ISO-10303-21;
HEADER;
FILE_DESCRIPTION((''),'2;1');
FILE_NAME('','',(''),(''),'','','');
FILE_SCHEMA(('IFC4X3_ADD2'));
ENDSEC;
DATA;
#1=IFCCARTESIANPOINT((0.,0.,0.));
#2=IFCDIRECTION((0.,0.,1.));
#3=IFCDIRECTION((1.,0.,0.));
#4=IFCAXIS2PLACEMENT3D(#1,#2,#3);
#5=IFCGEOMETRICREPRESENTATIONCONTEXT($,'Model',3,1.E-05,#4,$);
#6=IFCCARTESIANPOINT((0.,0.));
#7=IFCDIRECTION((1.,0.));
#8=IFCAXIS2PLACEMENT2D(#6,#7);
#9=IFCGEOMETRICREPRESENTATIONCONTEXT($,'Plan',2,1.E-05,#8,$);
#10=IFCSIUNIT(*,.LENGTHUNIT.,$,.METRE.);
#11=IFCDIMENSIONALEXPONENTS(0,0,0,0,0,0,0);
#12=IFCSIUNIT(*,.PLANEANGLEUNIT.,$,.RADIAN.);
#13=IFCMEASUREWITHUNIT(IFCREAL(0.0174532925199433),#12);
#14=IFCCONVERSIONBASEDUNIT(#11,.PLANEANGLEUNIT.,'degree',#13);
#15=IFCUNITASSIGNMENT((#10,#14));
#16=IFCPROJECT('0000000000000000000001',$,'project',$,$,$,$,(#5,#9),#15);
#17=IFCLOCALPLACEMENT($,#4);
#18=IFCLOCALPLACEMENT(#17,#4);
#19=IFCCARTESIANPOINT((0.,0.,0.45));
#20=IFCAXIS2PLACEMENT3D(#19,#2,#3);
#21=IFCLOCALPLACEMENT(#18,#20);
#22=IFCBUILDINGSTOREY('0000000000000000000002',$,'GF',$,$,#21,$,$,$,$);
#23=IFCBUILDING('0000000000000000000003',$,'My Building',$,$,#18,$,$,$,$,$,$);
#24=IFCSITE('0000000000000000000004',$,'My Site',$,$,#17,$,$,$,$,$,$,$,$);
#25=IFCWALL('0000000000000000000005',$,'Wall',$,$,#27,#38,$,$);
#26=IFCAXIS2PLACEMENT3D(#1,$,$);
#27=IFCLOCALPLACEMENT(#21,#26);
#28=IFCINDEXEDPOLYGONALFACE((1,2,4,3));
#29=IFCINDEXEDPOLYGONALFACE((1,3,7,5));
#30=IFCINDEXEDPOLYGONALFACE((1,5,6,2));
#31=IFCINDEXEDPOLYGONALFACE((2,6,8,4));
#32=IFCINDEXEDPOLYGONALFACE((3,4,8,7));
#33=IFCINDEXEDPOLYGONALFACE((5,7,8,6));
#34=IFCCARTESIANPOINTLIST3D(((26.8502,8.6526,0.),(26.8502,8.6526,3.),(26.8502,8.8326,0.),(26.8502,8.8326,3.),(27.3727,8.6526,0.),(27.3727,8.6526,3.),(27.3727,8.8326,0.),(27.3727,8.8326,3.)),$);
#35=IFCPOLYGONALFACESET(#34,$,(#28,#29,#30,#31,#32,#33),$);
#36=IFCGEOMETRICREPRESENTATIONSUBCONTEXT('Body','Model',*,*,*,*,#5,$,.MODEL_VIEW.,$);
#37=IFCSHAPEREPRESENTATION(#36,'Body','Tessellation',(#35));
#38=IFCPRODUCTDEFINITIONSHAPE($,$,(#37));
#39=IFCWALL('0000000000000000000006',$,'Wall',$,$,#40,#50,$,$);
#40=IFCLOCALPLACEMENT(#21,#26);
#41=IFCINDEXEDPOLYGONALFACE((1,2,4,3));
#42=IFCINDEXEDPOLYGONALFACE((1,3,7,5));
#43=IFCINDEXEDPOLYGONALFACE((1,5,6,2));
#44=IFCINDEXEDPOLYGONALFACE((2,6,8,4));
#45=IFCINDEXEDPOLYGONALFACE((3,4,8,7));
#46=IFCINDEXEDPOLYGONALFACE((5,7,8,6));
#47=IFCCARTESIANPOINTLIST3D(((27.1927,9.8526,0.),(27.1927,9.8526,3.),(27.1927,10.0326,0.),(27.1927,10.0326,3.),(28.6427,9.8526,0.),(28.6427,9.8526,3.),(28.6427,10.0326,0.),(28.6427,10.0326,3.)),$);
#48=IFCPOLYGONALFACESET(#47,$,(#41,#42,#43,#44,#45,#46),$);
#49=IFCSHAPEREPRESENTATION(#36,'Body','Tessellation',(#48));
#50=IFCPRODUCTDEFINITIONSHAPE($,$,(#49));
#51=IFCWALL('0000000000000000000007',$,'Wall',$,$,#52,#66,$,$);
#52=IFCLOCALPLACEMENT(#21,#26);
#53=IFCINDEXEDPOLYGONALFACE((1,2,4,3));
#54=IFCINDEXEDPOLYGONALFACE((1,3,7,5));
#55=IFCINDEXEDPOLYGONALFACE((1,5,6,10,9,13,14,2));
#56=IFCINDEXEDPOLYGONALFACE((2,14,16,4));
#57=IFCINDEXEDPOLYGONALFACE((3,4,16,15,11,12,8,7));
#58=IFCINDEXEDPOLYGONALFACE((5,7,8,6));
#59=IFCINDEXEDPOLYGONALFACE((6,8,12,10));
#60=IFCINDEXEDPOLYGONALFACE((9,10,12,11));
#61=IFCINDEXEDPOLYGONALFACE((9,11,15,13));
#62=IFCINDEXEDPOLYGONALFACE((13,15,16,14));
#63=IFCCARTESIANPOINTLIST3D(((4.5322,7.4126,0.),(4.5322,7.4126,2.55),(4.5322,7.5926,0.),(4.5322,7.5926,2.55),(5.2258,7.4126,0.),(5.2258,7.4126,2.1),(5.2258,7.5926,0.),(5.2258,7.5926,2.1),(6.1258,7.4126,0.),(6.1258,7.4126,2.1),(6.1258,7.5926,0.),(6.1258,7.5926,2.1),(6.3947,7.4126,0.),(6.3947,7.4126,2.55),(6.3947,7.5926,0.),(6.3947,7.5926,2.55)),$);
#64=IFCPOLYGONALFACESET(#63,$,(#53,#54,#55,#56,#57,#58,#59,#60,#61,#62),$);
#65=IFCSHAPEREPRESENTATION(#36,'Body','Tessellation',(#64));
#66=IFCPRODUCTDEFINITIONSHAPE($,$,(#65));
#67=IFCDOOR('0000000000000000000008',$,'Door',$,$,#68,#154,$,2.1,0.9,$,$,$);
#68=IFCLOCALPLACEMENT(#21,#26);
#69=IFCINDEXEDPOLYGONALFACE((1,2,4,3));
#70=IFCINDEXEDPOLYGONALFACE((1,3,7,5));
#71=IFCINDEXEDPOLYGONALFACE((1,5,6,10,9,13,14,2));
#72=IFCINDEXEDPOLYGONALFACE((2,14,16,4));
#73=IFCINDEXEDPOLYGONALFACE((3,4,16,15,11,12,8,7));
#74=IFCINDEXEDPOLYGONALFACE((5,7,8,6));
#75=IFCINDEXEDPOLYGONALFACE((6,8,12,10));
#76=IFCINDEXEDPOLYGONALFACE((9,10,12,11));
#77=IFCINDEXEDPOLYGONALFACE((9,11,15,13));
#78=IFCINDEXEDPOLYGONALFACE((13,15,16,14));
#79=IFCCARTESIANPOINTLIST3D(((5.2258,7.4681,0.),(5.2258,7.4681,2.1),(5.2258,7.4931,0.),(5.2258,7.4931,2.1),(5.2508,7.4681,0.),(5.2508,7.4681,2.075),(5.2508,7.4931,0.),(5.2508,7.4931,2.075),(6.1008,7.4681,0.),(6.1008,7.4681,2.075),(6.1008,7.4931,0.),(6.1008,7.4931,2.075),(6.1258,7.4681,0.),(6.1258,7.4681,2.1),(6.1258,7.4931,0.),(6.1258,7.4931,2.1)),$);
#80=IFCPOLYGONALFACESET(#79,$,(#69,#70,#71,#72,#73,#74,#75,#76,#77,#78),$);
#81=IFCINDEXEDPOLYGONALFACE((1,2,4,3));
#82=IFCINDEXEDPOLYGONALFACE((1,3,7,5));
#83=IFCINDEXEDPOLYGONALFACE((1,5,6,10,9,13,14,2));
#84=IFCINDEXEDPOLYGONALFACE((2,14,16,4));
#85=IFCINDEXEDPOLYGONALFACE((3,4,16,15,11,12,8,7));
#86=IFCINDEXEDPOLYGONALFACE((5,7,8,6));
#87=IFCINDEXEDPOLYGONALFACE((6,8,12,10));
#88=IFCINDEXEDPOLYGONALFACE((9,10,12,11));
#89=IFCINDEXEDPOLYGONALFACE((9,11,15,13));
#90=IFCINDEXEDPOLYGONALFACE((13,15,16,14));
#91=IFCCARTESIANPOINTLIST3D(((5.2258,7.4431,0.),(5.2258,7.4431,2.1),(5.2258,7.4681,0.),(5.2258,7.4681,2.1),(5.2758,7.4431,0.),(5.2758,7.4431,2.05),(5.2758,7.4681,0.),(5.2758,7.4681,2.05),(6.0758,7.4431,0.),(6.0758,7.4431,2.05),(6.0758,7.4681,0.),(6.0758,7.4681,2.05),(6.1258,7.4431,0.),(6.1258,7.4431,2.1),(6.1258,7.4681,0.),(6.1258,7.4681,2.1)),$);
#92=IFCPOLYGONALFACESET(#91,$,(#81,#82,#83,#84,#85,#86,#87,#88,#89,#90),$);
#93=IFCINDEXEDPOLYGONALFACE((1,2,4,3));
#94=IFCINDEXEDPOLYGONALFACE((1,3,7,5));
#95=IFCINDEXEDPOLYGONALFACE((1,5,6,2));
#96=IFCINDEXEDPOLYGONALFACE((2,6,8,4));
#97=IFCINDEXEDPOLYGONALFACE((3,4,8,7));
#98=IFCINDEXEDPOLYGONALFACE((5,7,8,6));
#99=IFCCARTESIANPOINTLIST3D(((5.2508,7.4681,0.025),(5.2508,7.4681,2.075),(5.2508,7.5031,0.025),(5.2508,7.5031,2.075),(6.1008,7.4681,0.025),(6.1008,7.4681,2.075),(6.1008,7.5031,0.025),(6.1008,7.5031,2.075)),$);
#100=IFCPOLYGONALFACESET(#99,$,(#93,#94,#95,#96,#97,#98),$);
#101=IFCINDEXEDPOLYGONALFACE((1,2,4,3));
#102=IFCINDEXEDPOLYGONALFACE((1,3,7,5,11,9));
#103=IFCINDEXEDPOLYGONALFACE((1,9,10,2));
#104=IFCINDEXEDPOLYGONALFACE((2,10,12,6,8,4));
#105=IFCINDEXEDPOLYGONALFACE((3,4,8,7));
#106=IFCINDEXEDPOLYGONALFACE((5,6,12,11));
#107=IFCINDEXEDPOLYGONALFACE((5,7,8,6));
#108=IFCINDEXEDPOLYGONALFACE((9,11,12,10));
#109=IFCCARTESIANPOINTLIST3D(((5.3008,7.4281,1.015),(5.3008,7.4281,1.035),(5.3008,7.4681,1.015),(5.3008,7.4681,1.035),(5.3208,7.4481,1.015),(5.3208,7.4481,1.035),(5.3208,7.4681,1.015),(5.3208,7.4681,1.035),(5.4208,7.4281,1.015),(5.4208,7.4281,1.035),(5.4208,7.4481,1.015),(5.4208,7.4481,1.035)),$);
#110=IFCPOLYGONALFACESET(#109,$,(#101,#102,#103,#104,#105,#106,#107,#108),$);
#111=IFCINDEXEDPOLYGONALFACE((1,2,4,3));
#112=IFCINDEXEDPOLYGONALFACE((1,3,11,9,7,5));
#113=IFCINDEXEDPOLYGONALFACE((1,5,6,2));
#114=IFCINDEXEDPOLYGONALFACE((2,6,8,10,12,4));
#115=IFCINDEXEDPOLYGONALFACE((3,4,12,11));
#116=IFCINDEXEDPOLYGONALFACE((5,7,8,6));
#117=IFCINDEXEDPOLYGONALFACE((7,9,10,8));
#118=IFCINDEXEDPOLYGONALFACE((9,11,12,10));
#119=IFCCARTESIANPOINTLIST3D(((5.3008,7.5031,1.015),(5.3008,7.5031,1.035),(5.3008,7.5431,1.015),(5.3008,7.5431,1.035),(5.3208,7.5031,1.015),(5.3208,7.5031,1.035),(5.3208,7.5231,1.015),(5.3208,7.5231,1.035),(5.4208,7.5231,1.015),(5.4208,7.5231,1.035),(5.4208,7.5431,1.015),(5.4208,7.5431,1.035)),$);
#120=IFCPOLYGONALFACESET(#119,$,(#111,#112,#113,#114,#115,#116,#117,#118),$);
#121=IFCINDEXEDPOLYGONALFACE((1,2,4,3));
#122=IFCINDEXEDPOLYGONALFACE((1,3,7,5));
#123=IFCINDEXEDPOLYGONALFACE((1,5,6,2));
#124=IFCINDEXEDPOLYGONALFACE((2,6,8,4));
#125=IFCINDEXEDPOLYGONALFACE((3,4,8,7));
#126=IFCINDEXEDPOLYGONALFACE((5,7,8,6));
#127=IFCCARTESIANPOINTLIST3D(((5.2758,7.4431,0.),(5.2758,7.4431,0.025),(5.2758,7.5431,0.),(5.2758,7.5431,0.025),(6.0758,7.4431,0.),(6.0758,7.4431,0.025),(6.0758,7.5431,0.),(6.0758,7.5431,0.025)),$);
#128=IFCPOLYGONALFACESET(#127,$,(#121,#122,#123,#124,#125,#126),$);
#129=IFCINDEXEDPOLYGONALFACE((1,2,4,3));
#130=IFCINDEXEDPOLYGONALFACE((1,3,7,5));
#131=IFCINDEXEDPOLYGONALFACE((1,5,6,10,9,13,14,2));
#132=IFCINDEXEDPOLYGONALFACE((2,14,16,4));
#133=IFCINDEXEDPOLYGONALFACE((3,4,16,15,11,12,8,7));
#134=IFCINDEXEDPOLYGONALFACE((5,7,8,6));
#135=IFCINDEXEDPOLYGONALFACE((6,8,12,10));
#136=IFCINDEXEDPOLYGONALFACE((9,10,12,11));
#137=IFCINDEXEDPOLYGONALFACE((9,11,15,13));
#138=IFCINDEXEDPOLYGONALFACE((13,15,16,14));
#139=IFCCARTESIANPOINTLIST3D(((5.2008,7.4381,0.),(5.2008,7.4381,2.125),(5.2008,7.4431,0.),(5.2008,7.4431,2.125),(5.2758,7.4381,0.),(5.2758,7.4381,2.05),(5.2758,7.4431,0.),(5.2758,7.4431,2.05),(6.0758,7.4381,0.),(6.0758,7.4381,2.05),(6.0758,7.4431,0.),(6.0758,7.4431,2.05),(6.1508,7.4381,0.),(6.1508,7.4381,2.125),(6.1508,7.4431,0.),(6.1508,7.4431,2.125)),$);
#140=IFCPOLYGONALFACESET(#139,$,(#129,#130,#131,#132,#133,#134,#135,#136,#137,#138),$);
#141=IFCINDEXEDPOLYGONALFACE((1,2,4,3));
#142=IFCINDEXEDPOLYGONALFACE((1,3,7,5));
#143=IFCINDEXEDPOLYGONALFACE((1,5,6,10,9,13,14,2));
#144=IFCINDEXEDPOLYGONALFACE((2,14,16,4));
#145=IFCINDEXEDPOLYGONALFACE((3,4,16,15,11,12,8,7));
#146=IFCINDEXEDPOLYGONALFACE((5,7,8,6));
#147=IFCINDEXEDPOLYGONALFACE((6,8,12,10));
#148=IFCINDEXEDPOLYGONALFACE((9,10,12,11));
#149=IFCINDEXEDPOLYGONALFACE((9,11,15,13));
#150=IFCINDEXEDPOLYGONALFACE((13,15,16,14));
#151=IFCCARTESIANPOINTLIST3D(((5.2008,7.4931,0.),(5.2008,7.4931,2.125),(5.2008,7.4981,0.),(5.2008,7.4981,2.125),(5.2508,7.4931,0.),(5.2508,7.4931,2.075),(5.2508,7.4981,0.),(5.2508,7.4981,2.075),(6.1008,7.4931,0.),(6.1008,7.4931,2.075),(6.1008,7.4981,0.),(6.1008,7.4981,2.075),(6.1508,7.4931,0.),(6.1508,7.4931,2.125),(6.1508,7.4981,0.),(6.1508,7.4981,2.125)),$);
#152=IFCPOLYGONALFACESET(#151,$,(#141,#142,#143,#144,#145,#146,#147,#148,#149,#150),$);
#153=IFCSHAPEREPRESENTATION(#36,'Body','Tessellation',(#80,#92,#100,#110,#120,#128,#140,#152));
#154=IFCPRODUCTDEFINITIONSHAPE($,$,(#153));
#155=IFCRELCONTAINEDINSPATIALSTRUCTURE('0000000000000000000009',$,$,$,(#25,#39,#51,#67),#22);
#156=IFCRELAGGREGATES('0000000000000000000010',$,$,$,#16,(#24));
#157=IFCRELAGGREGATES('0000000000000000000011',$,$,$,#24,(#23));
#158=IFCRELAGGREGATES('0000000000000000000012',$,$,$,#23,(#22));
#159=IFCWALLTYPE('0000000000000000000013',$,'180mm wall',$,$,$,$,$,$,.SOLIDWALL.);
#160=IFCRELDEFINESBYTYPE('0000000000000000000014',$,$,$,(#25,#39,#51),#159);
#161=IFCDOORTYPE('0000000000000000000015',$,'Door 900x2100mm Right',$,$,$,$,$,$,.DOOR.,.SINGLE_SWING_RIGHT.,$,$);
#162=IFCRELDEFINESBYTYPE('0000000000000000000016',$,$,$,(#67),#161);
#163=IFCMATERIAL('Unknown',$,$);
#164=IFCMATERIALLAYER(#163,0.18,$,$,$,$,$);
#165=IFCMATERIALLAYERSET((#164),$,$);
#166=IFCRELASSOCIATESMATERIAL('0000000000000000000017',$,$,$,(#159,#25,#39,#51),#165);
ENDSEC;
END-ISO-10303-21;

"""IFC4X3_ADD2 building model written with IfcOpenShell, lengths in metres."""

from ifc_helpers import new_model, entity, si_unit, converted_unit, frame, origin_with_axes, origin_2d_with_axis, place, context, subcontext, project, spatial, line, indexed_curve, outline, extrude, clip, halfspace, shape, source, transform, mapped, material, layer, layer_set, layer_usage, type_object, type_shapes, element, fill, save


model = new_model("IFC4X3_ADD2")

# Units and contexts
model_context = context("Model", 3, precision=1e-05, world=origin_with_axes())
plan_context = context("Plan", 2, precision=1e-05, world=origin_2d_with_axis())
body_context_1 = subcontext(model_context, "Body", "Model", "MODEL_VIEW")
body_context_2 = subcontext(plan_context, "Body", "Plan", "PLAN_VIEW")
ifc_project = project(units=[si_unit("LENGTHUNIT", "METRE"), converted_unit("PLANEANGLEUNIT", "degree", entity("IfcReal", 0.0174532925199433), si_unit("PLANEANGLEUNIT", "RADIAN"), dimensions=[0, 0, 0, 0, 0, 0, 0])], contexts=[model_context, plan_context])

# Site, building, storey
site_placement = place(None, origin_with_axes())
site = spatial("IfcSite", under=ifc_project, at=site_placement, Name="My Site")
building_placement = place(site_placement, origin_with_axes())
building = spatial("IfcBuilding", under=site, at=building_placement, Name="My Building")
storey_placement = place(building_placement, frame((0.0, 0.0, 0.45), z_axis=(0.0, 0.0, 1.0), x_axis=(1.0, 0.0, 0.0)))
storey = spatial("IfcBuildingStorey", under=building, at=storey_placement, Name="GF")

# Shared definitions
ifc_material_1 = material(Name="Unknown")

# Shared definitions
ifc_layer_1 = layer(ifc_material_1, 0.18)
ifc_layer_set_1 = layer_set([ifc_layer_1])
wall_type_1 = type_object("IfcWallType", Name="180mm wall", PredefinedType="SOLIDWALL", material=ifc_layer_set_1)

# Walls
ifc_layer_usage_1 = layer_usage(ifc_layer_set_1, "AXIS2", "POSITIVE", 0.0)
wall_1_placement = place(storey_placement, frame((27.3727, 8.8326, 0.0), z_axis=(0.0, 0.0, 1.0), x_axis=(-1.0, 0.0, 0.0)))
element("IfcWall", 1, at=wall_1_placement, inside=storey, type_object=wall_type_1, material=ifc_layer_usage_1, Name="Wall", context=body_context_1, shape_type="SweptSolid", body=[
    extrude(outline(indexed_curve([(0.0, 0.0), (0.0, 0.18), (0.5225, 0.18), (0.5225, 0.0), (0.0, 0.0)], self_intersect=False)), origin_with_axes(), (0.0, 0.0, 1.0), 3.0),
])
ifc_layer_usage_2 = layer_usage(ifc_layer_set_1, "AXIS2", "POSITIVE", 0.0)
wall_2_placement = place(storey_placement, frame((28.6427, 10.0326, 0.0), z_axis=(0.0, 0.0, 1.0), x_axis=(-1.0, 0.0, 0.0)))
element("IfcWall", 2, at=wall_2_placement, inside=storey, type_object=wall_type_1, material=ifc_layer_usage_2, Name="Wall", context=body_context_1, shape_type="SweptSolid", body=[
    extrude(outline(indexed_curve([(0.0, 0.0), (0.0, 0.18), (1.45, 0.18), (1.45, 0.0), (0.0, 0.0)], self_intersect=False)), origin_with_axes(), (0.0, 0.0, 1.0), 3.0),
])

# Wall, opening, door
ifc_layer_usage_3 = layer_usage(ifc_layer_set_1, "AXIS2", "POSITIVE", 0.0)
wall_3_placement = place(storey_placement, frame((6.3947, 7.5926, 0.0), z_axis=(0.0, 0.0, 1.0), x_axis=(-1.0, 0.0, 0.0)))
wall_3 = element("IfcWall", 3, at=wall_3_placement, inside=storey, type_object=wall_type_1, material=ifc_layer_usage_3, Name="Wall", context=body_context_1, shape_type="Clipping", body=[
    clip(extrude(outline(indexed_curve([(0.0, 0.0), (0.0, 0.18), (1.8625, 0.18), (1.8625, 0.0), (0.0, 0.0)], self_intersect=False)), origin_with_axes(), (0.0, 0.0, 1.0), 2.55), halfspace(frame((0.0, 0.0, 2.55), z_axis=(0.0, 0.0, 1.0), x_axis=(-1.0, 0.0, 0.0)), False)),
])
shared_shape_1 = source(origin_with_axes(), body_context_1, "Body", "SolidModel", [
    extrude(outline(indexed_curve([(0.0, 0.0), (0.9, 0.0), (0.9, 2.1), (0.0, 2.1)], segments=[line(1, 2, 3, 4, 1)])), frame((0.0, -0.6, 0.0), z_axis=(0.0, -1.0, 0.0), x_axis=(1.0, 0.0, 0.0)), (0.0, 0.0, -1.0), 1.2),
])
opening_1_placement = place(wall_3_placement, frame((1.1688, 0.1495, 0.0), z_axis=(0.0, 0.0, 1.0), x_axis=(-1.0, 0.0, 0.0)))
opening_1 = element("IfcOpeningElement", 4, at=opening_1_placement, cuts=wall_3, PredefinedType="OPENING", context=body_context_1, shape_type="MappedRepresentation", body=[
    mapped(shared_shape_1, transform((0.0, 0.0, 0.0), x_axis=(1.0, 0.0, 0.0), y_axis=(0.0, 1.0, 0.0), z_axis=(0.0, 0.0, 1.0), scale=1.0)),
])
door_type_1 = type_object("IfcDoorType", Name="Door 900x2100mm Right", OperationType="SINGLE_SWING_RIGHT", PredefinedType="DOOR")
shared_shape_2 = source(origin_with_axes(), body_context_1, "Body", "SweptSolid", [
    extrude(outline(indexed_curve([(0.0, 0.0), (0.0, 2.1), (0.9, 2.1), (0.9, 0.0), (0.875, 0.0), (0.875, 2.075), (0.025, 2.075), (0.025, 0.0)], segments=[line(1, 2, 3, 4, 5, 6, 7, 8, 1)])), frame((0.0, 0.025, 0.0), z_axis=(0.0, -1.0, 0.0), x_axis=(1.0, 0.0, 0.0)), (0.0, 0.0, -1.0), 0.025),
    extrude(outline(indexed_curve([(0.0, 0.0), (0.0, 2.1), (0.9, 2.1), (0.9, 0.0), (0.85, 0.0), (0.85, 2.05), (0.05, 2.05), (0.05, 0.0)], segments=[line(1, 2, 3, 4, 5, 6, 7, 8, 1)])), frame((0.0, 0.0, 0.0), z_axis=(0.0, -1.0, 0.0), x_axis=(1.0, 0.0, 0.0)), (0.0, 0.0, -1.0), 0.025),
    extrude(outline(indexed_curve([(0.0, 0.0), (0.85, 0.0), (0.85, 0.035), (0.0, 0.035)], segments=[line(1, 2, 3, 4, 1)])), frame((0.025, 0.025, 0.025), z_axis=(0.0, 0.0, 1.0), x_axis=(1.0, 0.0, 0.0)), (0.0, 0.0, 1.0), 2.05),
    extrude(outline(indexed_curve([(0.0, 0.0), (0.0, -0.04), (0.12, -0.04), (0.12, -0.02), (0.02, -0.02), (0.02, 0.0)], segments=[line(1, 2, 3, 4, 5, 6, 1)])), frame((0.075, 0.025, 1.015), z_axis=(0.0, 0.0, 1.0), x_axis=(1.0, 0.0, 0.0)), (0.0, 0.0, 1.0), 0.02),
    extrude(outline(indexed_curve([(0.0, 0.0), (0.0, 0.04), (0.12, 0.04), (0.12, 0.02), (0.02, 0.02), (0.02, 0.0)], segments=[line(1, 2, 3, 4, 5, 6, 1)])), frame((0.075, 0.06, 1.015), z_axis=(0.0, 0.0, 1.0), x_axis=(1.0, 0.0, 0.0)), (0.0, 0.0, 1.0), 0.02),
    extrude(outline(indexed_curve([(0.0, 0.0), (0.8, 0.0), (0.8, 0.1), (0.0, 0.1)], segments=[line(1, 2, 3, 4, 1)])), frame((0.05, 0.0, 0.0), z_axis=(0.0, 0.0, 1.0), x_axis=(1.0, 0.0, 0.0)), (0.0, 0.0, 1.0), 0.025),
    extrude(outline(indexed_curve([(0.0, 0.0), (0.0, 2.125), (0.95, 2.125), (0.95, 0.0), (0.875, 0.0), (0.875, 2.05), (0.075, 2.05), (0.075, 0.0)], segments=[line(1, 2, 3, 4, 5, 6, 7, 8, 1)])), frame((-0.025, -0.005, 0.0), z_axis=(0.0, -1.0, 0.0), x_axis=(1.0, 0.0, 0.0)), (0.0, 0.0, -1.0), 0.005),
    extrude(outline(indexed_curve([(0.0, 0.0), (0.0, 2.125), (0.95, 2.125), (0.95, 0.0), (0.9, 0.0), (0.9, 2.075), (0.05, 2.075), (0.05, 0.0)], segments=[line(1, 2, 3, 4, 5, 6, 7, 8, 1)])), frame((-0.025, 0.05, 0.0), z_axis=(0.0, -1.0, 0.0), x_axis=(1.0, 0.0, 0.0)), (0.0, 0.0, -1.0), 0.005),
])
shared_shape_3 = source(origin_with_axes(), body_context_2, "Body", "Curve2D", [
    entity("IfcIndexedPolyCurve", entity("IfcCartesianPointList2D", [[0.0, 0.0], [0.0, 0.05], [0.025, 0.05], [0.025, 0.025], [0.05, 0.025], [0.05, 0.0]]), [entity("IfcLineIndex", [1, 2, 3, 4, 5, 6, 1])]),
    entity("IfcIndexedPolyCurve", entity("IfcCartesianPointList2D", [[0.9, 0.0], [0.9, 0.05], [0.875, 0.05], [0.875, 0.025], [0.85, 0.025], [0.85, 0.0]]), [entity("IfcLineIndex", [1, 2, 3, 4, 5, 6, 1])]),
    entity("IfcTrimmedCurve", entity("IfcEllipse", entity("IfcAxis2Placement2D", entity("IfcCartesianPoint", [0.84, 0.05]), entity("IfcDirection", [1.0, 0.0])), 0.815, 0.85), [entity("IfcCartesianPoint", [0.84, 0.9])], [entity("IfcCartesianPoint", [0.025, 0.05])], True, "CARTESIAN"),
    entity("IfcIndexedPolyCurve", entity("IfcCartesianPointList2D", [[0.875, 0.05], [0.84, 0.05], [0.84, 0.9], [0.875, 0.9]]), [entity("IfcLineIndex", [1, 2, 3, 4, 1])]),
])
type_shapes(door_type_1, [shared_shape_2, shared_shape_3])
door_1_placement = place(opening_1_placement, frame((0.0, 0.0, 0.0), z_axis=(0.0, 0.0, 1.0), x_axis=(1.0, 0.0, 0.0)))
door_1 = element("IfcDoor", 5, at=door_1_placement, inside=storey, type_object=door_type_1, Name="Door", OverallHeight=2.1, OverallWidth=0.9, shapes=[
    shape(body_context_1, "Body", "MappedRepresentation", [mapped(shared_shape_2, transform((0.0, 0.0, 0.0), x_axis=(1.0, 0.0, 0.0), y_axis=(0.0, 1.0, 0.0), z_axis=(0.0, 0.0, 1.0), scale=1.0))]),
    shape(body_context_2, "Body", "MappedRepresentation", [mapped(shared_shape_3, transform((0.0, 0.0, 0.0), x_axis=(1.0, 0.0, 0.0), y_axis=(0.0, 1.0, 0.0), z_axis=(0.0, 0.0, 1.0), scale=1.0))]),
])
fill(opening_1, door_1)

save(model, "model.ifc")
